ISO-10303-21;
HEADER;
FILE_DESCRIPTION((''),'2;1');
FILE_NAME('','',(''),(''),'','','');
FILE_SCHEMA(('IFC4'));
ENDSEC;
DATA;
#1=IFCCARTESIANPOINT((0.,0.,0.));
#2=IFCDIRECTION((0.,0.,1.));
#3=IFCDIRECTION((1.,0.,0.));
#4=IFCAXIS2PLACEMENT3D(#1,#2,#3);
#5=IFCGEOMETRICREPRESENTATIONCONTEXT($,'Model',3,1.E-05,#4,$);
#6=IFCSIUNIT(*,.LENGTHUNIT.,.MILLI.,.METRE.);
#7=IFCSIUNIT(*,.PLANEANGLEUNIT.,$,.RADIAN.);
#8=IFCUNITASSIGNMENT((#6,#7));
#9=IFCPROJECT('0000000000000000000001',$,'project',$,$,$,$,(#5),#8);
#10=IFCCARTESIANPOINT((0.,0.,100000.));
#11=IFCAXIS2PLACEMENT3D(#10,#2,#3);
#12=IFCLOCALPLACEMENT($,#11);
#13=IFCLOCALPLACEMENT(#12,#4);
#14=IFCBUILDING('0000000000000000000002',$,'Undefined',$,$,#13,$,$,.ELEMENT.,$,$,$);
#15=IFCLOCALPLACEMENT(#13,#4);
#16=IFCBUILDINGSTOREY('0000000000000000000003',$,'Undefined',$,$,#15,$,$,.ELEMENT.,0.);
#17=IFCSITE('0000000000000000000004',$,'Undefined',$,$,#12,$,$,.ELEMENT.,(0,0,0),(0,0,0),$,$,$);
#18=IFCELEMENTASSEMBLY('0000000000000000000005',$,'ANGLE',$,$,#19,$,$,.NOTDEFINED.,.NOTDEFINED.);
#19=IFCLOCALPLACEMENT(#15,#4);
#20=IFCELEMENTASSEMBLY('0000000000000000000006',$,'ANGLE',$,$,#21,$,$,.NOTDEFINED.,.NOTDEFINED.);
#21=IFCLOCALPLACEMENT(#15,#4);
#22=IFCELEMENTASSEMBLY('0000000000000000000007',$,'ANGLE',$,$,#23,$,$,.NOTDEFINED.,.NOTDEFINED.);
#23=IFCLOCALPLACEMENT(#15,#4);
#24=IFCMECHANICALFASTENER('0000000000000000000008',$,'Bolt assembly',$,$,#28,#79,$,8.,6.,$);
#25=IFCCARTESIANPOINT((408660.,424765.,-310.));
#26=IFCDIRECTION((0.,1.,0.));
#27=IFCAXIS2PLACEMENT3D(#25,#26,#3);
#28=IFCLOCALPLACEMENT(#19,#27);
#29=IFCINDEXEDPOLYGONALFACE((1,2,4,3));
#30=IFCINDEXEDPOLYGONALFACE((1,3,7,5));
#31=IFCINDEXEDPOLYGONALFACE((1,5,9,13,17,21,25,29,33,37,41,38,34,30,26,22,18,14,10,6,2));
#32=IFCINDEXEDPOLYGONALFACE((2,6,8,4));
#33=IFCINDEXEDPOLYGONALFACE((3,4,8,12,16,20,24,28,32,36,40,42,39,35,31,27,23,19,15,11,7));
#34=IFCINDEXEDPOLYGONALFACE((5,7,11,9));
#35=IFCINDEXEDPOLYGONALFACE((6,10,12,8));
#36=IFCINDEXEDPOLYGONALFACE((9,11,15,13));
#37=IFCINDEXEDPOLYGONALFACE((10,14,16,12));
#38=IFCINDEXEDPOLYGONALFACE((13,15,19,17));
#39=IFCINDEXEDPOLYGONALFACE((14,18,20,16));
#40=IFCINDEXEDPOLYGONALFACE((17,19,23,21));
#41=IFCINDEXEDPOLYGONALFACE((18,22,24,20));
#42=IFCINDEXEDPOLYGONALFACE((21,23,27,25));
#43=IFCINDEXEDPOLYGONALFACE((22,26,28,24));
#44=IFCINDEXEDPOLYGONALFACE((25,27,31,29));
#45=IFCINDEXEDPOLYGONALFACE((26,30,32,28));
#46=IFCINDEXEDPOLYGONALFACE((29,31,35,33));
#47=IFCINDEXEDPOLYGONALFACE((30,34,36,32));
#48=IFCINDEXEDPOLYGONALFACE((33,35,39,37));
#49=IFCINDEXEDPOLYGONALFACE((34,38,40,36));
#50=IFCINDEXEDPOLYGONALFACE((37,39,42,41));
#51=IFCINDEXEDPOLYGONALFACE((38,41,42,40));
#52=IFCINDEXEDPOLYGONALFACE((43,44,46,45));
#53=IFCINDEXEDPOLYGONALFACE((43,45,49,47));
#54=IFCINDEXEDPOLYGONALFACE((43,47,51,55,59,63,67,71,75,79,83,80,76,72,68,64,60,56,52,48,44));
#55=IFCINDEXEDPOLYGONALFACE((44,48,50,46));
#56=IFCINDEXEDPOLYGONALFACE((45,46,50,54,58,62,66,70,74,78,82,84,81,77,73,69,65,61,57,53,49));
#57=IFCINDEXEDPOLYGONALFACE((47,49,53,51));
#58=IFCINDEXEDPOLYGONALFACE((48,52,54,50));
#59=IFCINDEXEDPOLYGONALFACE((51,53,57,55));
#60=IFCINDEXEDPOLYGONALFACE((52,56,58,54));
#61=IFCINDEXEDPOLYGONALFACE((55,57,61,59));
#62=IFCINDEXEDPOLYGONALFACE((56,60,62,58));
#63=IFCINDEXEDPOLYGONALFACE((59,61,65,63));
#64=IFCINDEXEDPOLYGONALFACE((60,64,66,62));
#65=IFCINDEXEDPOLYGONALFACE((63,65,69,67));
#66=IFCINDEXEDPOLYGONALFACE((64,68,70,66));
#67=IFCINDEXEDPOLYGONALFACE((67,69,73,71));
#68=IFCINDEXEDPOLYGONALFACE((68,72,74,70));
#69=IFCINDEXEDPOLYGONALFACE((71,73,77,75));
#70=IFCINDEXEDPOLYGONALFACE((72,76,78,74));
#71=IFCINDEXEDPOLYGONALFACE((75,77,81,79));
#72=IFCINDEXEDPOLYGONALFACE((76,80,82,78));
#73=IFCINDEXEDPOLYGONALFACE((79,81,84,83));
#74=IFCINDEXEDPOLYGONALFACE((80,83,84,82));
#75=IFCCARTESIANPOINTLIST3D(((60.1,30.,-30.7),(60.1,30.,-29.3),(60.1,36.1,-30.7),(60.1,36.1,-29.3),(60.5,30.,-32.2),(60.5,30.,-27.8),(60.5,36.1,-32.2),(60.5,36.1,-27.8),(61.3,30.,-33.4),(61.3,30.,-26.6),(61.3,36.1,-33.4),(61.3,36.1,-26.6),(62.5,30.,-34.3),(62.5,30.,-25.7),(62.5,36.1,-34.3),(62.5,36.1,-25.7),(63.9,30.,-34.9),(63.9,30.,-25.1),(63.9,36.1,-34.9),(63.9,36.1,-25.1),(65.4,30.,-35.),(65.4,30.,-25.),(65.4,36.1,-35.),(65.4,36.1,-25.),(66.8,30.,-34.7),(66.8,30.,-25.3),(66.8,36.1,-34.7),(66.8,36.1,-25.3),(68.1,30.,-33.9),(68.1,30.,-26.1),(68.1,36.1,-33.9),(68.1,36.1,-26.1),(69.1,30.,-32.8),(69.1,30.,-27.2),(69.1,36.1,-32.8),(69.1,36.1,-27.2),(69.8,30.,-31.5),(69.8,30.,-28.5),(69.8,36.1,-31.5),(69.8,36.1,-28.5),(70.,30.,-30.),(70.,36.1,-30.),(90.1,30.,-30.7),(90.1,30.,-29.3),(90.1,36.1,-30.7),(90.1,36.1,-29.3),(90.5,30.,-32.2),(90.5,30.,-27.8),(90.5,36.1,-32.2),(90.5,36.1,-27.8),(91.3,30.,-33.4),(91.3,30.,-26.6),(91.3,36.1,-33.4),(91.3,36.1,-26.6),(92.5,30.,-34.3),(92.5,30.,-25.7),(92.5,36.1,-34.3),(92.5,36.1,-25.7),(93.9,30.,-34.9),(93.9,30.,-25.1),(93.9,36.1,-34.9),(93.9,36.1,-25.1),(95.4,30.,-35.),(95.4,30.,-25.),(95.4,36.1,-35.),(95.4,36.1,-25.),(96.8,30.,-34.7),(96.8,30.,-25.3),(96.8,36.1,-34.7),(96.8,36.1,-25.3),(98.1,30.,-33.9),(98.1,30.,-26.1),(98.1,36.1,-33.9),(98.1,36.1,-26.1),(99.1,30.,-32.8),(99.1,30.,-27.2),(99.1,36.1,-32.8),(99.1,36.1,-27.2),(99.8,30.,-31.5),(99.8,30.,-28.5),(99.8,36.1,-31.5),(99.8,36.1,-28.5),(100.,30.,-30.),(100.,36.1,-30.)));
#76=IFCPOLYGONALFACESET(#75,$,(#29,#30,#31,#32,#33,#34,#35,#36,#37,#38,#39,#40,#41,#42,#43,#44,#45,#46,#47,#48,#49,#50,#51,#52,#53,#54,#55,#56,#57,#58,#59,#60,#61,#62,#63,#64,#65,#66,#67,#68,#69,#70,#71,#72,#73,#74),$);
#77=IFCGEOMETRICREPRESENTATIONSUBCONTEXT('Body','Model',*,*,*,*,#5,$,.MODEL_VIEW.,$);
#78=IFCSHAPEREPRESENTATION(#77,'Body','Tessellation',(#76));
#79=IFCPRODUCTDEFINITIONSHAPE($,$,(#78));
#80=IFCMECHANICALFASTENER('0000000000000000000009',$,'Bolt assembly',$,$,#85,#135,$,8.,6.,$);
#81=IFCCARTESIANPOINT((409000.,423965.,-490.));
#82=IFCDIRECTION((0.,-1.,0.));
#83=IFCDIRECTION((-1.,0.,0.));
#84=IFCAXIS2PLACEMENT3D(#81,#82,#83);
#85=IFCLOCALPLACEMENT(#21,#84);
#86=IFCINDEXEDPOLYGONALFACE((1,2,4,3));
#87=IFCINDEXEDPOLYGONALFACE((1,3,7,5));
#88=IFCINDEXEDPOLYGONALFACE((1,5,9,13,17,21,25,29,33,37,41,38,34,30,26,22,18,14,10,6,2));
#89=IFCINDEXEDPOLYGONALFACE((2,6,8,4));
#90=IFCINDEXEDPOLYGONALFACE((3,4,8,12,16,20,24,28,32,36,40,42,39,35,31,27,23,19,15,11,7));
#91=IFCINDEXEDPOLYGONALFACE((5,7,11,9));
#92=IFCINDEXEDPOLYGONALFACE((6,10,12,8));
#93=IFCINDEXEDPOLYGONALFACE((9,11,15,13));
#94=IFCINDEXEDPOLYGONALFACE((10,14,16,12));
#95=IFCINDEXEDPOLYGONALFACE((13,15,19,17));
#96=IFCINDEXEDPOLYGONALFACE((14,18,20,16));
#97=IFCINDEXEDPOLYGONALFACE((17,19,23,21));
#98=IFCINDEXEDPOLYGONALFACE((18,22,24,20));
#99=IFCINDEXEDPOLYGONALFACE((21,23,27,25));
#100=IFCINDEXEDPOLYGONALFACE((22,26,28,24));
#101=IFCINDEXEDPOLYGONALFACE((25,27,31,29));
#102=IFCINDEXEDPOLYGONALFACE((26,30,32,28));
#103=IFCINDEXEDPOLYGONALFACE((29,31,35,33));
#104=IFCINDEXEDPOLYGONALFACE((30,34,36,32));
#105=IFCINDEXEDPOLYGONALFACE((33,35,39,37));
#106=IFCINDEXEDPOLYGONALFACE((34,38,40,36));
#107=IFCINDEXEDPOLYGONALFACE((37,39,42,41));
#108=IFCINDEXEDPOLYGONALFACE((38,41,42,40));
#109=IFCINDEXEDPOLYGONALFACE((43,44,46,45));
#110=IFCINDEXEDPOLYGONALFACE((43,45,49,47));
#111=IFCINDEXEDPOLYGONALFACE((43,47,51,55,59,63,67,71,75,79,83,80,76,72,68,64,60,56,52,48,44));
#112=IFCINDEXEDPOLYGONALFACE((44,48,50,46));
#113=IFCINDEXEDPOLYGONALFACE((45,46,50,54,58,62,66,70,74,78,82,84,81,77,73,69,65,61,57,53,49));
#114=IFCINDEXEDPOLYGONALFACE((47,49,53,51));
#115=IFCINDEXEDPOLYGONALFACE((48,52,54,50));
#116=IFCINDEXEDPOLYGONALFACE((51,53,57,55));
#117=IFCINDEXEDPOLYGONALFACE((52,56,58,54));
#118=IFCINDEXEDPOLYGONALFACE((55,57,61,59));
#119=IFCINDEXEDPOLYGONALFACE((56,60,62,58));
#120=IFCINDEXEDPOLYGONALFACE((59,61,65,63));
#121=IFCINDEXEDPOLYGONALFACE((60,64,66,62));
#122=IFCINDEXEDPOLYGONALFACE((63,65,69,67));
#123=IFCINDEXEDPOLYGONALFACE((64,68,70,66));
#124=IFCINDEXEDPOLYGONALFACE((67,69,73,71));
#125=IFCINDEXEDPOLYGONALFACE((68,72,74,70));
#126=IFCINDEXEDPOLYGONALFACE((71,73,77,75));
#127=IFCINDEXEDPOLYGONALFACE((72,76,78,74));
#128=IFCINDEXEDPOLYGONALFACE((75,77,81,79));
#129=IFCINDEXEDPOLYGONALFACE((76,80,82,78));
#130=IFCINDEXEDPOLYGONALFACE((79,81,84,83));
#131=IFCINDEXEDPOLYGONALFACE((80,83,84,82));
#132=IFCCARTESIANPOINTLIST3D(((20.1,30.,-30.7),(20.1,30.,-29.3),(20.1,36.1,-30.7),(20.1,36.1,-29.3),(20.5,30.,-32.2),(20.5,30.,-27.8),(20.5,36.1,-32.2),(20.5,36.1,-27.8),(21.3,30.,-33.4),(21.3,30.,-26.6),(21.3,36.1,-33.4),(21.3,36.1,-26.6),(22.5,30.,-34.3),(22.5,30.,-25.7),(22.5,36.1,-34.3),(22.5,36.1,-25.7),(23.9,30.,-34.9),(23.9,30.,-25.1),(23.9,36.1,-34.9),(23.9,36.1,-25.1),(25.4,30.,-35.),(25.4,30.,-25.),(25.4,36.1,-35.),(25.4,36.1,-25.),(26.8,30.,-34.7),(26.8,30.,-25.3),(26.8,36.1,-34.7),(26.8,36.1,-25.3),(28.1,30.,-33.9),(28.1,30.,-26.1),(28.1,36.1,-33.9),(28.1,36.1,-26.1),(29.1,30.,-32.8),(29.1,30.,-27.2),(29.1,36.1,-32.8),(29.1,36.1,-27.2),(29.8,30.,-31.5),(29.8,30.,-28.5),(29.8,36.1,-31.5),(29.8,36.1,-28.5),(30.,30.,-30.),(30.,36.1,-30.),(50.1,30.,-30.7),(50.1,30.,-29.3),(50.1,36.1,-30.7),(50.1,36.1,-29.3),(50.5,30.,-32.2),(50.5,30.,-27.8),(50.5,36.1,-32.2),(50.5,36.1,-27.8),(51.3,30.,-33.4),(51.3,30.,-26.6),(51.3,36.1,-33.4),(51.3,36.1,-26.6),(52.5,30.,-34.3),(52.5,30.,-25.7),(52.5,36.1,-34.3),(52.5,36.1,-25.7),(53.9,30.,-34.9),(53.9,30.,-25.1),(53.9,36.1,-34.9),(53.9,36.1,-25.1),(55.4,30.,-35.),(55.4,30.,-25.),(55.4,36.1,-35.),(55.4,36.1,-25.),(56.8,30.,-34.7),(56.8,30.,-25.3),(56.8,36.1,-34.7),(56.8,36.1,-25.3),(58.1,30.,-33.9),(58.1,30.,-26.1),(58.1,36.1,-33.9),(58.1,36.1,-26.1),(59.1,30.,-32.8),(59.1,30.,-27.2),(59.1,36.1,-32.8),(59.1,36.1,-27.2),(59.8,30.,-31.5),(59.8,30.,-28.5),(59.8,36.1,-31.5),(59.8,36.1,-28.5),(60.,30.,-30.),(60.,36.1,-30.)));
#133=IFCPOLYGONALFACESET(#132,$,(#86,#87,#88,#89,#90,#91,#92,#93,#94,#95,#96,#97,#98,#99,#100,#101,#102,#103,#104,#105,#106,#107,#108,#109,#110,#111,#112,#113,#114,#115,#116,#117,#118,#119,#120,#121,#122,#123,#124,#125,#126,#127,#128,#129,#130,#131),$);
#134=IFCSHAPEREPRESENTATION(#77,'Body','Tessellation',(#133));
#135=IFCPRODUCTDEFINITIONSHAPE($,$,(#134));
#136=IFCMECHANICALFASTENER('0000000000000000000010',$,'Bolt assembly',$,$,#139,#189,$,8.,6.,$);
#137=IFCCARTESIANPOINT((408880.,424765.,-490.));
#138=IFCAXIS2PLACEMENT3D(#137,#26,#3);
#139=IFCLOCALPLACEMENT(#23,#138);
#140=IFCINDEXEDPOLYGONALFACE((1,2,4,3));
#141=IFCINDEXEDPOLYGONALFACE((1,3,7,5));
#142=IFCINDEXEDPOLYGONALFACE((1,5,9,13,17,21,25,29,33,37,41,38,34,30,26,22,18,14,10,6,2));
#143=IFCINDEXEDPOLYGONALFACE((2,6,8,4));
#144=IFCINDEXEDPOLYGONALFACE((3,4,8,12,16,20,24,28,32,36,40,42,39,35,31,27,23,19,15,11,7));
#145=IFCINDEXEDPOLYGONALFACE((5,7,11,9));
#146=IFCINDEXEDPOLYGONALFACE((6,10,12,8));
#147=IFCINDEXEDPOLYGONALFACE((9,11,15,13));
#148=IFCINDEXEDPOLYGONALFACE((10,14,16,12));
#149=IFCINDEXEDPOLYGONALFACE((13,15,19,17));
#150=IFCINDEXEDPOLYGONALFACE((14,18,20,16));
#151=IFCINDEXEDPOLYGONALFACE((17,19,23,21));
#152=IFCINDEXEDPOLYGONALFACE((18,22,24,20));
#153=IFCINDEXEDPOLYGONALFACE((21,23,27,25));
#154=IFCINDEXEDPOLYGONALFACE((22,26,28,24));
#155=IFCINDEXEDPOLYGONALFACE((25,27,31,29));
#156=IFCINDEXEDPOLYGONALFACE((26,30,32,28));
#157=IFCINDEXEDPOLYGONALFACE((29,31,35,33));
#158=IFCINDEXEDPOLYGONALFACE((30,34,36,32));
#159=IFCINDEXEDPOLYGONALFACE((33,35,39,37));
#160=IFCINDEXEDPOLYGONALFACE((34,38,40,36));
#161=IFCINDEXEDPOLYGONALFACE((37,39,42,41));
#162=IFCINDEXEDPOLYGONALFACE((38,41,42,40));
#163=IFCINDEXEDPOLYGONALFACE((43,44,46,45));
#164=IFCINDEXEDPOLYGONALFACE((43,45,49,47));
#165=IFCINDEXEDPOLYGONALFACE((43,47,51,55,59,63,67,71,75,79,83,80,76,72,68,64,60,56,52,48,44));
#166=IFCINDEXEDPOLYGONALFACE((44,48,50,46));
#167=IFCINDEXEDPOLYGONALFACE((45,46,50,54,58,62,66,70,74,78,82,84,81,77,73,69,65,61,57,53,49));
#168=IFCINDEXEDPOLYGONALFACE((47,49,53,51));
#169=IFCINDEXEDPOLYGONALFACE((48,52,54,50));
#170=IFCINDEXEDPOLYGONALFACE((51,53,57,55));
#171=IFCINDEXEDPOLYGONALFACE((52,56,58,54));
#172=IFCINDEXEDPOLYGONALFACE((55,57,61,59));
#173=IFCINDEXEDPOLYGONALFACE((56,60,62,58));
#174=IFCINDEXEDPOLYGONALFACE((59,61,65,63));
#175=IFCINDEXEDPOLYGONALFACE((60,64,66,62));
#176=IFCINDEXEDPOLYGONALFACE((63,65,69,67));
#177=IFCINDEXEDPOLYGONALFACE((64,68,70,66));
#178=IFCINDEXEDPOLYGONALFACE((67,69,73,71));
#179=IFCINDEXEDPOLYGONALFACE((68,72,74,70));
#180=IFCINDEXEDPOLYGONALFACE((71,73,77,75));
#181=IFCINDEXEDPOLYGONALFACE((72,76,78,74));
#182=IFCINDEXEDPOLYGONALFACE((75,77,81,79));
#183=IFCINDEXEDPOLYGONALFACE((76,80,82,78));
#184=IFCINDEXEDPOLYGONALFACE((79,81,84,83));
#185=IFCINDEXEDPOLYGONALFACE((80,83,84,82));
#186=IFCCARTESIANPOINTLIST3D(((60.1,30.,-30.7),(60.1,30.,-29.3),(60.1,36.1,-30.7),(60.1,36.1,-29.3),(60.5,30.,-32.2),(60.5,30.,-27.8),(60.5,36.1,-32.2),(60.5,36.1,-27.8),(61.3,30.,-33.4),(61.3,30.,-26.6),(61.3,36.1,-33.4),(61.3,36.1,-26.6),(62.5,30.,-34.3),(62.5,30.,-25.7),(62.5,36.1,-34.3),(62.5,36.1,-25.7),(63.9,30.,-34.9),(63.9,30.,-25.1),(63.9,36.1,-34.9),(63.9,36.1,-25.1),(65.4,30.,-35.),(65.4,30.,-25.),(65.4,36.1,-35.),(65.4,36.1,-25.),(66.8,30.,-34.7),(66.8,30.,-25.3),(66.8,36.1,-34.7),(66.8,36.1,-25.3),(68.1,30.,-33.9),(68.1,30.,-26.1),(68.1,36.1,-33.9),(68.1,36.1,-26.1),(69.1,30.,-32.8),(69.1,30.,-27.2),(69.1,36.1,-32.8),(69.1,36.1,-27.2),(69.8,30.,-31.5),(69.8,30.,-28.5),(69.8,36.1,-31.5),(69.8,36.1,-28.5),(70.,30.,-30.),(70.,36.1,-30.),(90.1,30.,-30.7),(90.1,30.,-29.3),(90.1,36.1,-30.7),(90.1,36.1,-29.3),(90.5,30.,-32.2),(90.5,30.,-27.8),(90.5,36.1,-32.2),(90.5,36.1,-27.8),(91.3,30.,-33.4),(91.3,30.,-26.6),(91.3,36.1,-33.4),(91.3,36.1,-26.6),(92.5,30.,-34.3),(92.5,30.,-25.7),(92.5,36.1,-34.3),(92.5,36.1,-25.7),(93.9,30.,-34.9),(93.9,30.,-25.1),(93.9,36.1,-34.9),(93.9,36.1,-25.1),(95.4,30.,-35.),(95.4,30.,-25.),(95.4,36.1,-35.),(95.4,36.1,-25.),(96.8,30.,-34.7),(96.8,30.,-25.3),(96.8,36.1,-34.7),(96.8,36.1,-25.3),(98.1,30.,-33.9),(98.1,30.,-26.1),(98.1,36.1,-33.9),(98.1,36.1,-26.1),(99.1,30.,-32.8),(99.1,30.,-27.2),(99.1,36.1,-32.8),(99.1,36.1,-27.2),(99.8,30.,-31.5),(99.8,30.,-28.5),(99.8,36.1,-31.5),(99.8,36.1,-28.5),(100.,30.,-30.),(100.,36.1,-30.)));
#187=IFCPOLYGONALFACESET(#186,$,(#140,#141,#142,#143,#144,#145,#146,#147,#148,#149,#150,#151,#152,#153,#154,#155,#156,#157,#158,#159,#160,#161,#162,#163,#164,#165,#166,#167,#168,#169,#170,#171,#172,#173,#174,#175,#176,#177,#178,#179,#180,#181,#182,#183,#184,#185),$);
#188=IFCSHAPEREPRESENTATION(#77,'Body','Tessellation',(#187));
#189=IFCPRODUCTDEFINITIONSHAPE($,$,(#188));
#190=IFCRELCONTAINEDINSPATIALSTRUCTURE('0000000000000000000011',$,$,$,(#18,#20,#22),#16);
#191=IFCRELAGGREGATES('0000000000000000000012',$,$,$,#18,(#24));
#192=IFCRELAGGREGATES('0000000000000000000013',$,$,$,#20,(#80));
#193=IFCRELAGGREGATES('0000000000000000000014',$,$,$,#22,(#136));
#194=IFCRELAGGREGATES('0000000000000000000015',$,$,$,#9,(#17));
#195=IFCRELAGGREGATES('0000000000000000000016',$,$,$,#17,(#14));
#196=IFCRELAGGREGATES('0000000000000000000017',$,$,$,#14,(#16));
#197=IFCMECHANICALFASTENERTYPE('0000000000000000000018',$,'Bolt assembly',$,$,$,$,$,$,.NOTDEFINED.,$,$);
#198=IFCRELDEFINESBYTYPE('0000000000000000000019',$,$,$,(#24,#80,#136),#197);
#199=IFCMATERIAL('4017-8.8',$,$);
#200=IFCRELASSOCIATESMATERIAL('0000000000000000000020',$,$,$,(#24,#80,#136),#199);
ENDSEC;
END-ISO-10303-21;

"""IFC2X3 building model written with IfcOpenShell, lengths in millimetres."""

from ifc_helpers import new_model, si_unit, frame, origin_with_axes, origin_2d_with_axis, place, context, subcontext, project, spatial, circle, extrude, source, transform, mapped, material, type_object, element, aggregate, save


model = new_model("IFC2X3")

# Units and contexts
model_context = context("Model", 3, precision=1e-05, world=origin_with_axes())
body_context = subcontext(model_context, "Body", "Model", "MODEL_VIEW")
ifc_project = project(units=[si_unit("LENGTHUNIT", "METRE", prefix="MILLI"), si_unit("PLANEANGLEUNIT", "RADIAN")], contexts=[model_context])

# Site, building, storey
site_placement = place(None, frame((0.0, 0.0, 100000.0), z_axis=(0.0, 0.0, 1.0), x_axis=(1.0, 0.0, 0.0)))
site = spatial("IfcSite", under=ifc_project, at=site_placement, Name="Undefined", CompositionType="ELEMENT", RefLatitude=(0, 0, 0), RefLongitude=(0, 0, 0))
building_placement = place(site_placement, origin_with_axes())
building = spatial("IfcBuilding", under=site, at=building_placement, Name="Undefined", CompositionType="ELEMENT")
storey_placement = place(building_placement, origin_with_axes())
storey = spatial("IfcBuildingStorey", under=building, at=storey_placement, Name="Undefined", CompositionType="ELEMENT", Elevation=0.0)

# Element assemblies
assembly_1_placement = place(storey_placement, origin_with_axes())
assembly_1 = element("IfcElementAssembly", 1, at=assembly_1_placement, inside=storey, Name="ANGLE", AssemblyPlace="NOTDEFINED", PredefinedType="NOTDEFINED")
assembly_2_placement = place(storey_placement, origin_with_axes())
assembly_2 = element("IfcElementAssembly", 2, at=assembly_2_placement, inside=storey, Name="ANGLE", AssemblyPlace="NOTDEFINED", PredefinedType="NOTDEFINED")
assembly_3_placement = place(storey_placement, origin_with_axes())
assembly_3 = element("IfcElementAssembly", 3, at=assembly_3_placement, inside=storey, Name="ANGLE", AssemblyPlace="NOTDEFINED", PredefinedType="NOTDEFINED")

# Shared definitions
ifc_material_1 = material(Name="4017-8.8")
mechanical_fastener_type = type_object("IfcMechanicalFastenerType", Name="Bolt assembly")

# Mechanical fasteners
shared_shape_1 = source(origin_with_axes(), body_context, "Body", "SweptSolid", [
    extrude(circle(Radius=5.0, at=origin_2d_with_axis()), frame((0.0, 30.0, 0.0), z_axis=(0.0, 1.0, 0.0), x_axis=(1.0, 0.0, 0.0)), (0.0, 0.0, 1.0), 6.1),
])
mechanical_fastener_1_placement = place(assembly_1_placement, frame((408660.0, 424765.0, -310.0), z_axis=(0.0, 1.0, 0.0), x_axis=(1.0, 0.0, 0.0)))
mechanical_fastener_1 = element("IfcMechanicalFastener", 4, at=mechanical_fastener_1_placement, type_object=mechanical_fastener_type, material=ifc_material_1, Name="Bolt assembly", NominalDiameter=8.0, NominalLength=6.0, context=body_context, shape_type="MappedRepresentation", body=[
    mapped(shared_shape_1, transform((95.0, 0.0, -30.0))),
    mapped(shared_shape_1, transform((65.0, 0.0, -30.0))),
])
aggregate(assembly_1, [mechanical_fastener_1])
mechanical_fastener_2_placement = place(assembly_2_placement, frame((409000.0, 423965.0, -490.0), z_axis=(0.0, -1.0, 0.0), x_axis=(-1.0, 0.0, 0.0)))
mechanical_fastener_2 = element("IfcMechanicalFastener", 5, at=mechanical_fastener_2_placement, type_object=mechanical_fastener_type, material=ifc_material_1, Name="Bolt assembly", NominalDiameter=8.0, NominalLength=6.0, context=body_context, shape_type="MappedRepresentation", body=[
    mapped(shared_shape_1, transform((25.0, 0.0, -30.0))),
    mapped(shared_shape_1, transform((55.0, 0.0, -30.0))),
])
mechanical_fastener_3_placement = place(assembly_3_placement, frame((408880.0, 424765.0, -490.0), z_axis=(0.0, 1.0, 0.0), x_axis=(1.0, 0.0, 0.0)))
mechanical_fastener_3 = element("IfcMechanicalFastener", 6, at=mechanical_fastener_3_placement, type_object=mechanical_fastener_type, material=ifc_material_1, Name="Bolt assembly", NominalDiameter=8.0, NominalLength=6.0, context=body_context, shape_type="MappedRepresentation", body=[
    mapped(shared_shape_1, transform((95.0, 0.0, -30.0))),
    mapped(shared_shape_1, transform((65.0, 0.0, -30.0))),
])
aggregate(assembly_2, [mechanical_fastener_2])
aggregate(assembly_3, [mechanical_fastener_3])

save(model, "model.ifc")
